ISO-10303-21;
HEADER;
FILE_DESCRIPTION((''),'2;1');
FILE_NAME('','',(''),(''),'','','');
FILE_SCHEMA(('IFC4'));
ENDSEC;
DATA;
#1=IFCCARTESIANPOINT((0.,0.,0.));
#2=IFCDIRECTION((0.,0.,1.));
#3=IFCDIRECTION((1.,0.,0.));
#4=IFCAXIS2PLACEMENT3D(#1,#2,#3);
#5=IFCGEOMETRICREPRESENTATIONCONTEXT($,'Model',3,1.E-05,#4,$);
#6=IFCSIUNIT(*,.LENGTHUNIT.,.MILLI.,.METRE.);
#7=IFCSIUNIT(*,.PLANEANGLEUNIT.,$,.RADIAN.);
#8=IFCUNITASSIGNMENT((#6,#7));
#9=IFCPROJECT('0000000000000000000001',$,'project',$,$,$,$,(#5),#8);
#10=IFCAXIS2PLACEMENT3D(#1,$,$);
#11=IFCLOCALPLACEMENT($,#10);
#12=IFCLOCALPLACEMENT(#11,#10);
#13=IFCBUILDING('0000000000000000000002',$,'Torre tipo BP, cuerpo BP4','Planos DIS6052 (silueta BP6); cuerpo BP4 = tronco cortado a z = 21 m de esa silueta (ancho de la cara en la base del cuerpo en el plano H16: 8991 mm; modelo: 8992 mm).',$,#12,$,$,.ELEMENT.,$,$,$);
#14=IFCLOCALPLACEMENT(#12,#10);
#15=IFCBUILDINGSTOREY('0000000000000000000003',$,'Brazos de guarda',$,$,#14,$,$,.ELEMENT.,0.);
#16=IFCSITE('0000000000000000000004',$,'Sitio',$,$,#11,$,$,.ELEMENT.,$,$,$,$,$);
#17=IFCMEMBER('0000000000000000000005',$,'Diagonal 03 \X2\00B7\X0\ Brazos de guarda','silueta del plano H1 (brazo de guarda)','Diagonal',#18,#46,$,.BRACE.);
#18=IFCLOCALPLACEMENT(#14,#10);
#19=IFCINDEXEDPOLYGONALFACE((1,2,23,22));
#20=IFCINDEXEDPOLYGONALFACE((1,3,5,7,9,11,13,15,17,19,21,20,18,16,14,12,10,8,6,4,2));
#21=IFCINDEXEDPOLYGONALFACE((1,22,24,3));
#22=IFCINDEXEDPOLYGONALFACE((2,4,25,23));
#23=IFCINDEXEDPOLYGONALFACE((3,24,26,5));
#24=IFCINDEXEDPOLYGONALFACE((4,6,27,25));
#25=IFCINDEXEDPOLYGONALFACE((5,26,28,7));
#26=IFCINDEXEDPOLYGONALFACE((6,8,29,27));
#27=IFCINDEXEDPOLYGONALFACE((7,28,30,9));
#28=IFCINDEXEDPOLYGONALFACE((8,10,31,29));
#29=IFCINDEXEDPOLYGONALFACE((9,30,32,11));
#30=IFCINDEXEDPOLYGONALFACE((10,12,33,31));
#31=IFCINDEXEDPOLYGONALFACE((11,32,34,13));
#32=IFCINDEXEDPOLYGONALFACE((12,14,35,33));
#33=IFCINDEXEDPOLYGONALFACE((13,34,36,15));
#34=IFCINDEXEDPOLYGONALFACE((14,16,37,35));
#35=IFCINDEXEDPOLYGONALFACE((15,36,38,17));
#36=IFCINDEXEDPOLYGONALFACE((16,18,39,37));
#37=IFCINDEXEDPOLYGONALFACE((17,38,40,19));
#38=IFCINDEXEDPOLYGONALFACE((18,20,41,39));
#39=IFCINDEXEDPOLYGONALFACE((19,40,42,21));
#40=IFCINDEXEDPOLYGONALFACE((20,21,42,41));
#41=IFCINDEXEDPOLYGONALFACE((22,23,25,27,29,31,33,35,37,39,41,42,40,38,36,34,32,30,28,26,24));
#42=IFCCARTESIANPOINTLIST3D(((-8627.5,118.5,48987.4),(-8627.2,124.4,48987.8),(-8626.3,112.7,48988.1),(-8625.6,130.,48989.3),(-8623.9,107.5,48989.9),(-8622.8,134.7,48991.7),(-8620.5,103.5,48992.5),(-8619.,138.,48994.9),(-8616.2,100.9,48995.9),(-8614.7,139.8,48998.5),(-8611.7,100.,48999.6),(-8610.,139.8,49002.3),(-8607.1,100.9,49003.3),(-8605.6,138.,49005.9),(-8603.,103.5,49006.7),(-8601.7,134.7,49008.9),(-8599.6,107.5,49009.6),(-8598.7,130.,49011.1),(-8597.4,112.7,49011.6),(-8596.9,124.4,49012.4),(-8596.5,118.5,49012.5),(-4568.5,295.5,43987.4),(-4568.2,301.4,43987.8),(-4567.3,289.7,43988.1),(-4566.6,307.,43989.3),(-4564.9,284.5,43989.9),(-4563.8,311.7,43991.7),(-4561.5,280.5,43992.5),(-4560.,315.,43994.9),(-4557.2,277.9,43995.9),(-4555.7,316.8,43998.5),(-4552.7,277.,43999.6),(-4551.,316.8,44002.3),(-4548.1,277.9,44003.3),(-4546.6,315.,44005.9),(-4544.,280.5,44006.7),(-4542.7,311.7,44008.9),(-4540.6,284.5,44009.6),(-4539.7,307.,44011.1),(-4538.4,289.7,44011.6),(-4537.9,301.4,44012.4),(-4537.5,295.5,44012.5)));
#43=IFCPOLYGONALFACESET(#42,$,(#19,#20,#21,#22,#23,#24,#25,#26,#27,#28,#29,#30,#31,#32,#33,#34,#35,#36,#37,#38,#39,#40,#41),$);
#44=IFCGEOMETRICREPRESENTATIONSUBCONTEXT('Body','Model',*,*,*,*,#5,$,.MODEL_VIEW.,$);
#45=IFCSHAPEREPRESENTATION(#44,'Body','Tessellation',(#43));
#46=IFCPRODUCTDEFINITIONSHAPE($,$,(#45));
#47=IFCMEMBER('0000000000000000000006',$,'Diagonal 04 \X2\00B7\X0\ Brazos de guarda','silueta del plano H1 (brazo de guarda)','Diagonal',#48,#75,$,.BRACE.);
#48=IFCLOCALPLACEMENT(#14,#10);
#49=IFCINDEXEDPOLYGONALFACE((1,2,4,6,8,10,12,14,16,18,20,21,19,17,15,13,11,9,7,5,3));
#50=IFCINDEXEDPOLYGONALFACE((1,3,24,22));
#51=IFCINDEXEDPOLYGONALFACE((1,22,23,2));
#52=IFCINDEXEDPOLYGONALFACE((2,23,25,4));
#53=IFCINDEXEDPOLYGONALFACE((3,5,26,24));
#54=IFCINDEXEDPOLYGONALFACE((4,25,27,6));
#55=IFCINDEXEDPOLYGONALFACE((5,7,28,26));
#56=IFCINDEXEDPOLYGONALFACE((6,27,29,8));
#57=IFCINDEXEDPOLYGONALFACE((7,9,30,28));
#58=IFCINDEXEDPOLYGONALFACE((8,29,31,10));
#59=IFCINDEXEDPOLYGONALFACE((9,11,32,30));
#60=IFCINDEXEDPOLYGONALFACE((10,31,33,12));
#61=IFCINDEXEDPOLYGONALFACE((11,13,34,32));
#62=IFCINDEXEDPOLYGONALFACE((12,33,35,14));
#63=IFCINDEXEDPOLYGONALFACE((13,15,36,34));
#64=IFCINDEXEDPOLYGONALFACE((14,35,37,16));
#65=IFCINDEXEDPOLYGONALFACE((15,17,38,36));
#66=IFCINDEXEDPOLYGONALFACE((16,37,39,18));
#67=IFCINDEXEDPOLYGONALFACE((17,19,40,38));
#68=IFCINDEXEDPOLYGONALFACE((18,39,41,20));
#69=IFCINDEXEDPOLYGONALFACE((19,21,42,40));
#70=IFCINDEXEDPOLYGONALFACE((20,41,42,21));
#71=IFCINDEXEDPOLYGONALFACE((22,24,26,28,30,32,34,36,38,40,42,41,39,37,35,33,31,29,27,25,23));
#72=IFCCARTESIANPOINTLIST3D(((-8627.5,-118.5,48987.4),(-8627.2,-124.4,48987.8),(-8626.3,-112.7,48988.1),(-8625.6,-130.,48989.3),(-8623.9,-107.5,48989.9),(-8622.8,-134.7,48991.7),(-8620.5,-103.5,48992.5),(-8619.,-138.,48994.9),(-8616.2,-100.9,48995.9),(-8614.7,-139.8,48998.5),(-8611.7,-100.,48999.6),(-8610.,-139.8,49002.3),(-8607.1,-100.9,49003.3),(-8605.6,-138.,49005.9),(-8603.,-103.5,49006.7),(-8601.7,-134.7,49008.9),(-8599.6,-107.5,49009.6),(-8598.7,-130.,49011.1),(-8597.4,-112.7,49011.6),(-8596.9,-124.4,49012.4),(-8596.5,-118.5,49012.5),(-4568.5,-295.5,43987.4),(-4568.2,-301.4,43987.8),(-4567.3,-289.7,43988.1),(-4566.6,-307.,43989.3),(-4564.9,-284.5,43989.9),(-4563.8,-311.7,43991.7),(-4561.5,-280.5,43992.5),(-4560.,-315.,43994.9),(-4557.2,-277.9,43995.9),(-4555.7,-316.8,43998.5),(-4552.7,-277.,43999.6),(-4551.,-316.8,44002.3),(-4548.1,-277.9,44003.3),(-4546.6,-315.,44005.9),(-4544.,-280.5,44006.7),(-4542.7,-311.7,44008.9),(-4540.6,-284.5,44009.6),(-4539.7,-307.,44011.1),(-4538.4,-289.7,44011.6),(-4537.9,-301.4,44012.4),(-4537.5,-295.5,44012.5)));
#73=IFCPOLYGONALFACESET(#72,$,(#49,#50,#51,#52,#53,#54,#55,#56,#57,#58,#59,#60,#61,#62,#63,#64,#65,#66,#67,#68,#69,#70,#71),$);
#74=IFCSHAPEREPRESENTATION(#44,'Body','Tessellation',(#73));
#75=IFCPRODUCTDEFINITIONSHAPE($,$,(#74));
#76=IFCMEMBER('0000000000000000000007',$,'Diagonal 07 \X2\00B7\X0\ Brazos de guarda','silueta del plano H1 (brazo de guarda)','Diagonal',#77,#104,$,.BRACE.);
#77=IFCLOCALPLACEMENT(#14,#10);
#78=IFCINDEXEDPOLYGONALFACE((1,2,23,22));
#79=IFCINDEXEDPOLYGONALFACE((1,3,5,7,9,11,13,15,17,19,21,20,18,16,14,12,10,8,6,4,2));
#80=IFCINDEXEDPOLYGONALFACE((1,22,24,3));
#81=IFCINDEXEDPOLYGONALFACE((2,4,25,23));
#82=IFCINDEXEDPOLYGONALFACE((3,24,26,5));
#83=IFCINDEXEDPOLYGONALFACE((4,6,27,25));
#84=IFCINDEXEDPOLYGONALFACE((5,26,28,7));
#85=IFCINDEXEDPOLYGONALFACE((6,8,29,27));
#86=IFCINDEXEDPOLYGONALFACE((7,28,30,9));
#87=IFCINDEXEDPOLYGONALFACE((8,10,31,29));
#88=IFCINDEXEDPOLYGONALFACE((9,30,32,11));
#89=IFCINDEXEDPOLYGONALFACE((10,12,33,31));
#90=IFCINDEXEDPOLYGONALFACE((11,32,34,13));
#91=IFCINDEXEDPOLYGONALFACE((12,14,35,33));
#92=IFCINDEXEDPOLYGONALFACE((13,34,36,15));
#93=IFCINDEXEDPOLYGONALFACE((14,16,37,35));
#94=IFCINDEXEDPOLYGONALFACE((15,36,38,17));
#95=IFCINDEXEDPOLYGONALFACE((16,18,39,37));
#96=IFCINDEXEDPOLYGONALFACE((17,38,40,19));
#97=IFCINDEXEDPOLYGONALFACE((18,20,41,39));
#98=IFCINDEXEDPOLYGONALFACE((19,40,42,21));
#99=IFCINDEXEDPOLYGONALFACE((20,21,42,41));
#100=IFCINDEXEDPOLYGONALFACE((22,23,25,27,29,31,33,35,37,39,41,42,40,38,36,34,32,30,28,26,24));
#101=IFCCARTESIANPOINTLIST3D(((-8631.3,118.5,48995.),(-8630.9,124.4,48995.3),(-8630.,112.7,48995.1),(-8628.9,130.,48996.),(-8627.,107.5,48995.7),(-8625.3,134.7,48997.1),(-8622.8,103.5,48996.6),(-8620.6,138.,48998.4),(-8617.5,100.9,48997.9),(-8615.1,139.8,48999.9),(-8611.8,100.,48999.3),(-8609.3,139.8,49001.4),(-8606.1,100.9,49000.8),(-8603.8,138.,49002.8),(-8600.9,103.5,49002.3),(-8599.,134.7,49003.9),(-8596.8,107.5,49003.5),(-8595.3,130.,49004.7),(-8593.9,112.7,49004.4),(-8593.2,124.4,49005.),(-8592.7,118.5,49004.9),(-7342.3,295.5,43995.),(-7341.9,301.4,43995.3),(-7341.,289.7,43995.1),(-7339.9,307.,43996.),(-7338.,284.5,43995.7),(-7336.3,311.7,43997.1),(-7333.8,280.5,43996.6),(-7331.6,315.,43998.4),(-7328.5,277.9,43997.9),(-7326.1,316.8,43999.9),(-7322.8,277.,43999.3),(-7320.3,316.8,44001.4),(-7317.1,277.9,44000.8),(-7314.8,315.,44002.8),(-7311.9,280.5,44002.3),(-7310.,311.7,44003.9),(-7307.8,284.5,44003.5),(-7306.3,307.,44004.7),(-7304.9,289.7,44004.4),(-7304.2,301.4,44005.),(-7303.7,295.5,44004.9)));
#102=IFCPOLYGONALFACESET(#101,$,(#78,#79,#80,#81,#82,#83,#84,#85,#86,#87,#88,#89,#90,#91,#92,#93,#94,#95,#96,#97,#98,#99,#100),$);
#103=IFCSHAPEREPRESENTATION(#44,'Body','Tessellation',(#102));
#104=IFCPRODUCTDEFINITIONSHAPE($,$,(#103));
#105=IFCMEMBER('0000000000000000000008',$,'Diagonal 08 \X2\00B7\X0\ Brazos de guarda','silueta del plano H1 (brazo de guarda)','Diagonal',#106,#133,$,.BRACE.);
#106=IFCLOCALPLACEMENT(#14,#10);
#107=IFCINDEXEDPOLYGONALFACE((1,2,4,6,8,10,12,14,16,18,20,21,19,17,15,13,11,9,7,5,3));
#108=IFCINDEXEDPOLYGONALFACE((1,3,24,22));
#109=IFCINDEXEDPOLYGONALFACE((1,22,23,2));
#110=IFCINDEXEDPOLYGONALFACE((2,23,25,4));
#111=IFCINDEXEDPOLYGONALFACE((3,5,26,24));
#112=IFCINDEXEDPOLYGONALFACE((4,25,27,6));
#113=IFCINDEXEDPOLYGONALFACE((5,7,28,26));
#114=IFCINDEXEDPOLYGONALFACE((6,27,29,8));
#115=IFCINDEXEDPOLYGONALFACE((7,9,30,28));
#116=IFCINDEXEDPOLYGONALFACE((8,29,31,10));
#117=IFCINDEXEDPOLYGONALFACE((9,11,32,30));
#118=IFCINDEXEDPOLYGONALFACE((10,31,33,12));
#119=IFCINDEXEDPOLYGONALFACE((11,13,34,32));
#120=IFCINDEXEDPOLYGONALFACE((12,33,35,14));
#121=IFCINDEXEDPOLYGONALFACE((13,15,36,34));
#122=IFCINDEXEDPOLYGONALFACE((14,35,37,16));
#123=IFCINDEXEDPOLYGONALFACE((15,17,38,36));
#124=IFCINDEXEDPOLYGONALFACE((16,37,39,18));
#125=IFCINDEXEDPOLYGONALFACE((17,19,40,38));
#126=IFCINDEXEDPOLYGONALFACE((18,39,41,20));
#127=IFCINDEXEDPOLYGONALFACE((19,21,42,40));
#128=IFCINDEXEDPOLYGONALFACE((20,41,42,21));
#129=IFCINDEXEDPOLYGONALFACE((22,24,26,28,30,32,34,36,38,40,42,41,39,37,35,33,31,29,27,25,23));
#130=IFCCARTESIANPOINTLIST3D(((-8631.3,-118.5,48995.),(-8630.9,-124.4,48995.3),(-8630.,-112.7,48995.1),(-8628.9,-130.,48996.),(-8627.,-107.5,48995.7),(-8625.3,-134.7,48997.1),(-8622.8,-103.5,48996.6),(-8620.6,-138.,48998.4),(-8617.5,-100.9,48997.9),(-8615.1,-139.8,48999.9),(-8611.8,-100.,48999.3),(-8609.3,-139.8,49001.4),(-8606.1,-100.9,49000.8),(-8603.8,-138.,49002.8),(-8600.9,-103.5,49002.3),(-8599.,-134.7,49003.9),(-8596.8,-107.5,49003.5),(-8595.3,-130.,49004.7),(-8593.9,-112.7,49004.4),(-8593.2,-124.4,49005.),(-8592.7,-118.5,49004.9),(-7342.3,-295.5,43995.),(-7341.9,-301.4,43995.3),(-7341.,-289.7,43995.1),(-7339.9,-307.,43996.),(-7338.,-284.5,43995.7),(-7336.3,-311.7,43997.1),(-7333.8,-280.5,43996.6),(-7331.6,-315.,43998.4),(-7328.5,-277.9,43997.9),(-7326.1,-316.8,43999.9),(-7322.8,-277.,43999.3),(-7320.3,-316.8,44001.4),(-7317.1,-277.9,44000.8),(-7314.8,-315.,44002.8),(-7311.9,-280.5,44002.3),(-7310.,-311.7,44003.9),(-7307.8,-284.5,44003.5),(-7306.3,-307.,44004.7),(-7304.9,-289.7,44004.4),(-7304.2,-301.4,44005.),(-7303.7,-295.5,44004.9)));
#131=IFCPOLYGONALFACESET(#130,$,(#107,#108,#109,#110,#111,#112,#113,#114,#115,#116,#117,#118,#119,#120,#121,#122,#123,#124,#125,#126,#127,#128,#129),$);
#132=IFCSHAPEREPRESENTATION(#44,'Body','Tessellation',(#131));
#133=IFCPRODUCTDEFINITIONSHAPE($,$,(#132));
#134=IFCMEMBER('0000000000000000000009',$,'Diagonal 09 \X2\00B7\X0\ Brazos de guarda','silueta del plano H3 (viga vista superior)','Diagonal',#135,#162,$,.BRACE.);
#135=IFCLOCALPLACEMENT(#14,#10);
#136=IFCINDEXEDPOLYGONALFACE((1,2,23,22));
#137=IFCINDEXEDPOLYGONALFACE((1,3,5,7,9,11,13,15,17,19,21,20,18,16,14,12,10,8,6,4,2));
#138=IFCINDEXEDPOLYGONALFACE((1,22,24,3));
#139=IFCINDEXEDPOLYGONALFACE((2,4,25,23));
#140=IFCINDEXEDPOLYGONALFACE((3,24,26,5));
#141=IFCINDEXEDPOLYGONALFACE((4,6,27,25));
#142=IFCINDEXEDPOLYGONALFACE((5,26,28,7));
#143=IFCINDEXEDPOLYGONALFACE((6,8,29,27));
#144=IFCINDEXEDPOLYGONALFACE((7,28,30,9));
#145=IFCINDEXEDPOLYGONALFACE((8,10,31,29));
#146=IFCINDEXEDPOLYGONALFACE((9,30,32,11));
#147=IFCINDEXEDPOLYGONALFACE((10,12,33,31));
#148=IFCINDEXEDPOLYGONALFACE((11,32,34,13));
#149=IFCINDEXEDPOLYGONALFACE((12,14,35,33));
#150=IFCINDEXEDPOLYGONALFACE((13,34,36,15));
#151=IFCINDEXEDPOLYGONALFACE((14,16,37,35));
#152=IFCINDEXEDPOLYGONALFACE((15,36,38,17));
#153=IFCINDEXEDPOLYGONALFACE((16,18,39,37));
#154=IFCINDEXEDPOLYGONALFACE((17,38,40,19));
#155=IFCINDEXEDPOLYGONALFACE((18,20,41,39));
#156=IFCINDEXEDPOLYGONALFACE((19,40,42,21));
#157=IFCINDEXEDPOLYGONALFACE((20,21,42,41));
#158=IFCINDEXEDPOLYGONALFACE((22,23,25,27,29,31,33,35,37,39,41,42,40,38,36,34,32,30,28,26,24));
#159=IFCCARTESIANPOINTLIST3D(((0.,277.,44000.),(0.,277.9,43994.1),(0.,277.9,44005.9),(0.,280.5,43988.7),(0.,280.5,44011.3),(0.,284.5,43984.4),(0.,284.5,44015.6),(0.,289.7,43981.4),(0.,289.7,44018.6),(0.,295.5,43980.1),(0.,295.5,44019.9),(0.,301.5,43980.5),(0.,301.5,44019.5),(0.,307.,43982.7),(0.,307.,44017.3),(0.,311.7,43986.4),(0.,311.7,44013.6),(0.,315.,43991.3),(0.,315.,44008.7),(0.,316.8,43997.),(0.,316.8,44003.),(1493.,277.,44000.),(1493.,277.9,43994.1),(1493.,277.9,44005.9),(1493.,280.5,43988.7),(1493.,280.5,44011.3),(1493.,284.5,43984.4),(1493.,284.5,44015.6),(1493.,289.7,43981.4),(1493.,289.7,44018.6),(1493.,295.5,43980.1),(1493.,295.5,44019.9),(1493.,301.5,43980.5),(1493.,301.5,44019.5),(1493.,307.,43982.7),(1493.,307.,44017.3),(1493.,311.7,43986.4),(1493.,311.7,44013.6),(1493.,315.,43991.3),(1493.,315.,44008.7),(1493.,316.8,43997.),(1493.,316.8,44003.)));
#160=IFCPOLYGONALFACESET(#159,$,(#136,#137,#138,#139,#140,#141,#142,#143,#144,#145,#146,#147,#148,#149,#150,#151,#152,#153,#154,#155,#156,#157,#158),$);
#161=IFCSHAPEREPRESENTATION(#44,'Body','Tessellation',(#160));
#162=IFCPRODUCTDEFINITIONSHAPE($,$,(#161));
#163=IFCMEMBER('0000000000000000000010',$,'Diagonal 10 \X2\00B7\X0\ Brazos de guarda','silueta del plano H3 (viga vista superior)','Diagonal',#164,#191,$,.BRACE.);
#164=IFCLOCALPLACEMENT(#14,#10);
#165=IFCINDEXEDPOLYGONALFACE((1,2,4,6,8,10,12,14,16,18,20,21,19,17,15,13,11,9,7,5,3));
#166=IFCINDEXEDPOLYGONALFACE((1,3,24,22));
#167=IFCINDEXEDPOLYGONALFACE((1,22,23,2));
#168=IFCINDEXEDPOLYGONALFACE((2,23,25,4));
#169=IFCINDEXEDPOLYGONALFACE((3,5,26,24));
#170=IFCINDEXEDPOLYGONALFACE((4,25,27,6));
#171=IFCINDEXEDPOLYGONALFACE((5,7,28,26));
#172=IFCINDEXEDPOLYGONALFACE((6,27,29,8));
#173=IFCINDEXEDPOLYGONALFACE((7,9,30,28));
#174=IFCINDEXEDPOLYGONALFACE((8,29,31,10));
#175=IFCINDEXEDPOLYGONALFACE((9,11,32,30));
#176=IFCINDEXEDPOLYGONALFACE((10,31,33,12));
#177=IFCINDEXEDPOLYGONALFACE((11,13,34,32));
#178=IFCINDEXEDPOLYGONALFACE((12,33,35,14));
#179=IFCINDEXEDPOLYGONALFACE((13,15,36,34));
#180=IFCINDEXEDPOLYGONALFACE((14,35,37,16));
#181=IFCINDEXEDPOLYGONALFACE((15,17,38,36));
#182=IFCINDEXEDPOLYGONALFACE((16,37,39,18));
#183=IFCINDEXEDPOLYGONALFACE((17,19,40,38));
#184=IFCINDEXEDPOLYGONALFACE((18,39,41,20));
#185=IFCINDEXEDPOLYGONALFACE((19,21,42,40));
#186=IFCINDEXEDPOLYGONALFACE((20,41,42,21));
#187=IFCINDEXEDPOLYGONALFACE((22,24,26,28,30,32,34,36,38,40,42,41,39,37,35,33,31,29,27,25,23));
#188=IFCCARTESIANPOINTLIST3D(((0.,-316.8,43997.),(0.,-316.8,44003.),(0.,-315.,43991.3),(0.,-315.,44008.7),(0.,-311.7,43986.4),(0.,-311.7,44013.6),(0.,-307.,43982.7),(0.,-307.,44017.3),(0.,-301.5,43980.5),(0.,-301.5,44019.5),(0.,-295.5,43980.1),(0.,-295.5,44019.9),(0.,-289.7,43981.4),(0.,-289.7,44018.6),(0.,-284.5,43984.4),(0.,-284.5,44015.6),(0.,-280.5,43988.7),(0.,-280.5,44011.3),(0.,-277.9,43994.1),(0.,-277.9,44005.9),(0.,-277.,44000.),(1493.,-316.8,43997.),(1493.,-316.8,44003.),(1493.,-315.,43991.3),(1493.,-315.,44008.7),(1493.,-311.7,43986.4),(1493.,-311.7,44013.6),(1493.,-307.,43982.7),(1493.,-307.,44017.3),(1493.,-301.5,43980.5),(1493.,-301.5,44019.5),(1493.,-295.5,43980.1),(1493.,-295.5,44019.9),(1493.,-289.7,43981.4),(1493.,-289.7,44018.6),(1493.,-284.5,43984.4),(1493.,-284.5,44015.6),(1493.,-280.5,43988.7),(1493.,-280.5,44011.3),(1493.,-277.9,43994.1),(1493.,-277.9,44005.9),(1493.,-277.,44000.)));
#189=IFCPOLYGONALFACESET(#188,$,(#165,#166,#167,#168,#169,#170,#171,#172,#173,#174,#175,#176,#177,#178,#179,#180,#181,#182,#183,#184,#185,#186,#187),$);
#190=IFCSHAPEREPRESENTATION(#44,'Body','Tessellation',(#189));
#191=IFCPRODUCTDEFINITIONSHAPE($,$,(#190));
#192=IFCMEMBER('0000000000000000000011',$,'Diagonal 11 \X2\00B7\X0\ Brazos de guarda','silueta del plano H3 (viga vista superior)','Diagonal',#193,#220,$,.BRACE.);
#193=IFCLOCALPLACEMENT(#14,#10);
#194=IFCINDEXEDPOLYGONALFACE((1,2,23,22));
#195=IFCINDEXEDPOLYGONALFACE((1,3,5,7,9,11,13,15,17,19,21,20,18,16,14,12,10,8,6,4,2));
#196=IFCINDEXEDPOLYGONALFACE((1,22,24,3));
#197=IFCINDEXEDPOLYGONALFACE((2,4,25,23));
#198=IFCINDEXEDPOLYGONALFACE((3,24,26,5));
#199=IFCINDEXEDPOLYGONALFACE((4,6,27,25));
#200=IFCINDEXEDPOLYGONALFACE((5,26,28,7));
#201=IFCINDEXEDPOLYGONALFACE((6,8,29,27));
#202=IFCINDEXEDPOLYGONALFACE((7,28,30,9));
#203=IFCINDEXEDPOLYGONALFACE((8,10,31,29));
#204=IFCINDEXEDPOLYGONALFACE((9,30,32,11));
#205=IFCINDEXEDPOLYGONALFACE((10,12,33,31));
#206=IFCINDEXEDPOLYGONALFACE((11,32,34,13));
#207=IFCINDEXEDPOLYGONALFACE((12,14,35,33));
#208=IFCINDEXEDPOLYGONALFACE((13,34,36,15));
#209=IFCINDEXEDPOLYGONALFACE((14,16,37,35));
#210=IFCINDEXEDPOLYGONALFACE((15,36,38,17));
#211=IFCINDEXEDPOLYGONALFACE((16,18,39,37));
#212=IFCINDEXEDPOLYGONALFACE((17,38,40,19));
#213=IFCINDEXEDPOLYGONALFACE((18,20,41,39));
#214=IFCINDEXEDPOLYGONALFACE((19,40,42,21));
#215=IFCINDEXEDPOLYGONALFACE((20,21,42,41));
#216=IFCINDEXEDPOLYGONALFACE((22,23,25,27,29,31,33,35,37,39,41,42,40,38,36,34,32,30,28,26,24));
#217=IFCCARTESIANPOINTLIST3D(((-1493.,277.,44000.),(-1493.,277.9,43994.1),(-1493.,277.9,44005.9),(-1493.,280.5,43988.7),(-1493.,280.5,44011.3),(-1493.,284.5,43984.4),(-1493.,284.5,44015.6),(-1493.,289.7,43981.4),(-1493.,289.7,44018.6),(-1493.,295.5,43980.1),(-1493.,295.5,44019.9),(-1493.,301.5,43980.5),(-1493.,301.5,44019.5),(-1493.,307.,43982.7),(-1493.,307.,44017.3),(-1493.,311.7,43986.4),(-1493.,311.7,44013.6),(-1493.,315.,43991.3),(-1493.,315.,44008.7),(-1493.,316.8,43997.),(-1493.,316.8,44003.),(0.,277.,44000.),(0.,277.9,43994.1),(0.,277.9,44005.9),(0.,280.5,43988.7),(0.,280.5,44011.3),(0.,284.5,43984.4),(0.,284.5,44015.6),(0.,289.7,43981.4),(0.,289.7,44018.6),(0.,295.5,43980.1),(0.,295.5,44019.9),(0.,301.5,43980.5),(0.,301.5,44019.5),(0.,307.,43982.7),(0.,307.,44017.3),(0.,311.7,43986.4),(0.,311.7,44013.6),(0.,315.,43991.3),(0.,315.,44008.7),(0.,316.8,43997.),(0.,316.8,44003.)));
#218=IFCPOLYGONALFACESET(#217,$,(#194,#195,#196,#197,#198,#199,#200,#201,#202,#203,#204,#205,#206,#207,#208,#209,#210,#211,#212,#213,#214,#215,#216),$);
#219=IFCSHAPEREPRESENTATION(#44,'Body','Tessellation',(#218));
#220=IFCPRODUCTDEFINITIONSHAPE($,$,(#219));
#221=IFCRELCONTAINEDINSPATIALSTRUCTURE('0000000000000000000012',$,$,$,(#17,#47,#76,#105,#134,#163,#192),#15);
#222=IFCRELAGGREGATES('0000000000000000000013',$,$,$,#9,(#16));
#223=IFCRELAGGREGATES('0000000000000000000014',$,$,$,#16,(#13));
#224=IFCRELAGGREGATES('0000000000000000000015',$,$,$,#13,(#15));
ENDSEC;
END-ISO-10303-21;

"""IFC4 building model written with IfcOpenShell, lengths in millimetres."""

from ifc_helpers import new_model, si_unit, frame, origin, origin_with_axes, place, context, subcontext, project, spatial, circle, extrude, element, save


model = new_model("IFC4")

# Units and contexts
model_context = context("Model", 3, precision=1e-05, world=origin_with_axes())
body_context = subcontext(model_context, "Body", "Model", "MODEL_VIEW")
ifc_project = project(units=[si_unit("LENGTHUNIT", "METRE", prefix="MILLI"), si_unit("PLANEANGLEUNIT", "RADIAN")], contexts=[model_context])

# Site, building, storey
site_placement = place(None, origin())
site = spatial("IfcSite", under=ifc_project, at=site_placement, Name="Sitio", CompositionType="ELEMENT")
building_placement = place(site_placement, origin())
building = spatial("IfcBuilding", under=site, at=building_placement, Name="Torre tipo BP, cuerpo BP4", Description="Planos DIS6052 (silueta BP6); cuerpo BP4 = tronco cortado a z = 21 m de esa silueta (ancho de la cara en la base del cuerpo en el plano H16: 8991 mm; modelo: 8992 mm).", CompositionType="ELEMENT")
storey_placement = place(building_placement, origin())
storey = spatial("IfcBuildingStorey", under=building, at=storey_placement, Name="Brazos de guarda", CompositionType="ELEMENT", Elevation=0.0)

# Members
for number, where, z_axis, x_axis, name in (
    (1, (-4553.0, 297.0, 44000.0), (-0.630027, -0.027473, 0.776087), (0.017316, -0.999623, -0.02133), "Diagonal 03 · Brazos de guarda"),
    (2, (-4553.0, -297.0, 44000.0), (-0.630027, 0.027473, 0.776087), (0.017316, 0.999623, -0.02133), "Diagonal 04 · Brazos de guarda"),
):
    element("IfcMember", number, at=place(storey_placement, frame(where, z_axis=z_axis, x_axis=x_axis)), inside=storey, Name=name, Description="silueta del plano H1 (brazo de guarda)", ObjectType="Diagonal", PredefinedType="BRACE", context=body_context, shape_type="SweptSolid", body=[
        extrude(circle(Radius=20.0), None, (0.0, 0.0, 1.0), 6442.6),
    ])
for number, where, z_axis, x_axis, name in (
    (3, (-7323.0, 297.0, 44000.0), (-0.249491, -0.034259, 0.967771), (0.008552, -0.999413, -0.033174), "Diagonal 07 · Brazos de guarda"),
    (4, (-7323.0, -297.0, 44000.0), (-0.249491, 0.034259, 0.967771), (0.008552, 0.999413, -0.033174), "Diagonal 08 · Brazos de guarda"),
):
    element("IfcMember", number, at=place(storey_placement, frame(where, z_axis=z_axis, x_axis=x_axis)), inside=storey, Name=name, Description="silueta del plano H1 (brazo de guarda)", ObjectType="Diagonal", PredefinedType="BRACE", context=body_context, shape_type="SweptSolid", body=[
        extrude(circle(Radius=20.0), None, (0.0, 0.0, 1.0), 5166.5),
    ])
for number, where, z_axis, x_axis, name in (
    (5, (0.0, 297.0, 44000.0), (1.0, 0.0, 0.0), (0.0, -1.0, 0.0), "Diagonal 09 · Brazos de guarda"),
    (6, (0.0, -297.0, 44000.0), (1.0, 0.0, 0.0), (0.0, 1.0, 0.0), "Diagonal 10 · Brazos de guarda"),
    (7, (0.0, 297.0, 44000.0), (-1.0, 0.0, 0.0), (0.0, -1.0, 0.0), "Diagonal 11 · Brazos de guarda"),
):
    element("IfcMember", number, at=place(storey_placement, frame(where, z_axis=z_axis, x_axis=x_axis)), inside=storey, Name=name, Description="silueta del plano H3 (viga vista superior)", ObjectType="Diagonal", PredefinedType="BRACE", context=body_context, shape_type="SweptSolid", body=[
        extrude(circle(Radius=20.0), None, (0.0, 0.0, 1.0), 1493.0),
    ])

save(model, "model.ifc")
